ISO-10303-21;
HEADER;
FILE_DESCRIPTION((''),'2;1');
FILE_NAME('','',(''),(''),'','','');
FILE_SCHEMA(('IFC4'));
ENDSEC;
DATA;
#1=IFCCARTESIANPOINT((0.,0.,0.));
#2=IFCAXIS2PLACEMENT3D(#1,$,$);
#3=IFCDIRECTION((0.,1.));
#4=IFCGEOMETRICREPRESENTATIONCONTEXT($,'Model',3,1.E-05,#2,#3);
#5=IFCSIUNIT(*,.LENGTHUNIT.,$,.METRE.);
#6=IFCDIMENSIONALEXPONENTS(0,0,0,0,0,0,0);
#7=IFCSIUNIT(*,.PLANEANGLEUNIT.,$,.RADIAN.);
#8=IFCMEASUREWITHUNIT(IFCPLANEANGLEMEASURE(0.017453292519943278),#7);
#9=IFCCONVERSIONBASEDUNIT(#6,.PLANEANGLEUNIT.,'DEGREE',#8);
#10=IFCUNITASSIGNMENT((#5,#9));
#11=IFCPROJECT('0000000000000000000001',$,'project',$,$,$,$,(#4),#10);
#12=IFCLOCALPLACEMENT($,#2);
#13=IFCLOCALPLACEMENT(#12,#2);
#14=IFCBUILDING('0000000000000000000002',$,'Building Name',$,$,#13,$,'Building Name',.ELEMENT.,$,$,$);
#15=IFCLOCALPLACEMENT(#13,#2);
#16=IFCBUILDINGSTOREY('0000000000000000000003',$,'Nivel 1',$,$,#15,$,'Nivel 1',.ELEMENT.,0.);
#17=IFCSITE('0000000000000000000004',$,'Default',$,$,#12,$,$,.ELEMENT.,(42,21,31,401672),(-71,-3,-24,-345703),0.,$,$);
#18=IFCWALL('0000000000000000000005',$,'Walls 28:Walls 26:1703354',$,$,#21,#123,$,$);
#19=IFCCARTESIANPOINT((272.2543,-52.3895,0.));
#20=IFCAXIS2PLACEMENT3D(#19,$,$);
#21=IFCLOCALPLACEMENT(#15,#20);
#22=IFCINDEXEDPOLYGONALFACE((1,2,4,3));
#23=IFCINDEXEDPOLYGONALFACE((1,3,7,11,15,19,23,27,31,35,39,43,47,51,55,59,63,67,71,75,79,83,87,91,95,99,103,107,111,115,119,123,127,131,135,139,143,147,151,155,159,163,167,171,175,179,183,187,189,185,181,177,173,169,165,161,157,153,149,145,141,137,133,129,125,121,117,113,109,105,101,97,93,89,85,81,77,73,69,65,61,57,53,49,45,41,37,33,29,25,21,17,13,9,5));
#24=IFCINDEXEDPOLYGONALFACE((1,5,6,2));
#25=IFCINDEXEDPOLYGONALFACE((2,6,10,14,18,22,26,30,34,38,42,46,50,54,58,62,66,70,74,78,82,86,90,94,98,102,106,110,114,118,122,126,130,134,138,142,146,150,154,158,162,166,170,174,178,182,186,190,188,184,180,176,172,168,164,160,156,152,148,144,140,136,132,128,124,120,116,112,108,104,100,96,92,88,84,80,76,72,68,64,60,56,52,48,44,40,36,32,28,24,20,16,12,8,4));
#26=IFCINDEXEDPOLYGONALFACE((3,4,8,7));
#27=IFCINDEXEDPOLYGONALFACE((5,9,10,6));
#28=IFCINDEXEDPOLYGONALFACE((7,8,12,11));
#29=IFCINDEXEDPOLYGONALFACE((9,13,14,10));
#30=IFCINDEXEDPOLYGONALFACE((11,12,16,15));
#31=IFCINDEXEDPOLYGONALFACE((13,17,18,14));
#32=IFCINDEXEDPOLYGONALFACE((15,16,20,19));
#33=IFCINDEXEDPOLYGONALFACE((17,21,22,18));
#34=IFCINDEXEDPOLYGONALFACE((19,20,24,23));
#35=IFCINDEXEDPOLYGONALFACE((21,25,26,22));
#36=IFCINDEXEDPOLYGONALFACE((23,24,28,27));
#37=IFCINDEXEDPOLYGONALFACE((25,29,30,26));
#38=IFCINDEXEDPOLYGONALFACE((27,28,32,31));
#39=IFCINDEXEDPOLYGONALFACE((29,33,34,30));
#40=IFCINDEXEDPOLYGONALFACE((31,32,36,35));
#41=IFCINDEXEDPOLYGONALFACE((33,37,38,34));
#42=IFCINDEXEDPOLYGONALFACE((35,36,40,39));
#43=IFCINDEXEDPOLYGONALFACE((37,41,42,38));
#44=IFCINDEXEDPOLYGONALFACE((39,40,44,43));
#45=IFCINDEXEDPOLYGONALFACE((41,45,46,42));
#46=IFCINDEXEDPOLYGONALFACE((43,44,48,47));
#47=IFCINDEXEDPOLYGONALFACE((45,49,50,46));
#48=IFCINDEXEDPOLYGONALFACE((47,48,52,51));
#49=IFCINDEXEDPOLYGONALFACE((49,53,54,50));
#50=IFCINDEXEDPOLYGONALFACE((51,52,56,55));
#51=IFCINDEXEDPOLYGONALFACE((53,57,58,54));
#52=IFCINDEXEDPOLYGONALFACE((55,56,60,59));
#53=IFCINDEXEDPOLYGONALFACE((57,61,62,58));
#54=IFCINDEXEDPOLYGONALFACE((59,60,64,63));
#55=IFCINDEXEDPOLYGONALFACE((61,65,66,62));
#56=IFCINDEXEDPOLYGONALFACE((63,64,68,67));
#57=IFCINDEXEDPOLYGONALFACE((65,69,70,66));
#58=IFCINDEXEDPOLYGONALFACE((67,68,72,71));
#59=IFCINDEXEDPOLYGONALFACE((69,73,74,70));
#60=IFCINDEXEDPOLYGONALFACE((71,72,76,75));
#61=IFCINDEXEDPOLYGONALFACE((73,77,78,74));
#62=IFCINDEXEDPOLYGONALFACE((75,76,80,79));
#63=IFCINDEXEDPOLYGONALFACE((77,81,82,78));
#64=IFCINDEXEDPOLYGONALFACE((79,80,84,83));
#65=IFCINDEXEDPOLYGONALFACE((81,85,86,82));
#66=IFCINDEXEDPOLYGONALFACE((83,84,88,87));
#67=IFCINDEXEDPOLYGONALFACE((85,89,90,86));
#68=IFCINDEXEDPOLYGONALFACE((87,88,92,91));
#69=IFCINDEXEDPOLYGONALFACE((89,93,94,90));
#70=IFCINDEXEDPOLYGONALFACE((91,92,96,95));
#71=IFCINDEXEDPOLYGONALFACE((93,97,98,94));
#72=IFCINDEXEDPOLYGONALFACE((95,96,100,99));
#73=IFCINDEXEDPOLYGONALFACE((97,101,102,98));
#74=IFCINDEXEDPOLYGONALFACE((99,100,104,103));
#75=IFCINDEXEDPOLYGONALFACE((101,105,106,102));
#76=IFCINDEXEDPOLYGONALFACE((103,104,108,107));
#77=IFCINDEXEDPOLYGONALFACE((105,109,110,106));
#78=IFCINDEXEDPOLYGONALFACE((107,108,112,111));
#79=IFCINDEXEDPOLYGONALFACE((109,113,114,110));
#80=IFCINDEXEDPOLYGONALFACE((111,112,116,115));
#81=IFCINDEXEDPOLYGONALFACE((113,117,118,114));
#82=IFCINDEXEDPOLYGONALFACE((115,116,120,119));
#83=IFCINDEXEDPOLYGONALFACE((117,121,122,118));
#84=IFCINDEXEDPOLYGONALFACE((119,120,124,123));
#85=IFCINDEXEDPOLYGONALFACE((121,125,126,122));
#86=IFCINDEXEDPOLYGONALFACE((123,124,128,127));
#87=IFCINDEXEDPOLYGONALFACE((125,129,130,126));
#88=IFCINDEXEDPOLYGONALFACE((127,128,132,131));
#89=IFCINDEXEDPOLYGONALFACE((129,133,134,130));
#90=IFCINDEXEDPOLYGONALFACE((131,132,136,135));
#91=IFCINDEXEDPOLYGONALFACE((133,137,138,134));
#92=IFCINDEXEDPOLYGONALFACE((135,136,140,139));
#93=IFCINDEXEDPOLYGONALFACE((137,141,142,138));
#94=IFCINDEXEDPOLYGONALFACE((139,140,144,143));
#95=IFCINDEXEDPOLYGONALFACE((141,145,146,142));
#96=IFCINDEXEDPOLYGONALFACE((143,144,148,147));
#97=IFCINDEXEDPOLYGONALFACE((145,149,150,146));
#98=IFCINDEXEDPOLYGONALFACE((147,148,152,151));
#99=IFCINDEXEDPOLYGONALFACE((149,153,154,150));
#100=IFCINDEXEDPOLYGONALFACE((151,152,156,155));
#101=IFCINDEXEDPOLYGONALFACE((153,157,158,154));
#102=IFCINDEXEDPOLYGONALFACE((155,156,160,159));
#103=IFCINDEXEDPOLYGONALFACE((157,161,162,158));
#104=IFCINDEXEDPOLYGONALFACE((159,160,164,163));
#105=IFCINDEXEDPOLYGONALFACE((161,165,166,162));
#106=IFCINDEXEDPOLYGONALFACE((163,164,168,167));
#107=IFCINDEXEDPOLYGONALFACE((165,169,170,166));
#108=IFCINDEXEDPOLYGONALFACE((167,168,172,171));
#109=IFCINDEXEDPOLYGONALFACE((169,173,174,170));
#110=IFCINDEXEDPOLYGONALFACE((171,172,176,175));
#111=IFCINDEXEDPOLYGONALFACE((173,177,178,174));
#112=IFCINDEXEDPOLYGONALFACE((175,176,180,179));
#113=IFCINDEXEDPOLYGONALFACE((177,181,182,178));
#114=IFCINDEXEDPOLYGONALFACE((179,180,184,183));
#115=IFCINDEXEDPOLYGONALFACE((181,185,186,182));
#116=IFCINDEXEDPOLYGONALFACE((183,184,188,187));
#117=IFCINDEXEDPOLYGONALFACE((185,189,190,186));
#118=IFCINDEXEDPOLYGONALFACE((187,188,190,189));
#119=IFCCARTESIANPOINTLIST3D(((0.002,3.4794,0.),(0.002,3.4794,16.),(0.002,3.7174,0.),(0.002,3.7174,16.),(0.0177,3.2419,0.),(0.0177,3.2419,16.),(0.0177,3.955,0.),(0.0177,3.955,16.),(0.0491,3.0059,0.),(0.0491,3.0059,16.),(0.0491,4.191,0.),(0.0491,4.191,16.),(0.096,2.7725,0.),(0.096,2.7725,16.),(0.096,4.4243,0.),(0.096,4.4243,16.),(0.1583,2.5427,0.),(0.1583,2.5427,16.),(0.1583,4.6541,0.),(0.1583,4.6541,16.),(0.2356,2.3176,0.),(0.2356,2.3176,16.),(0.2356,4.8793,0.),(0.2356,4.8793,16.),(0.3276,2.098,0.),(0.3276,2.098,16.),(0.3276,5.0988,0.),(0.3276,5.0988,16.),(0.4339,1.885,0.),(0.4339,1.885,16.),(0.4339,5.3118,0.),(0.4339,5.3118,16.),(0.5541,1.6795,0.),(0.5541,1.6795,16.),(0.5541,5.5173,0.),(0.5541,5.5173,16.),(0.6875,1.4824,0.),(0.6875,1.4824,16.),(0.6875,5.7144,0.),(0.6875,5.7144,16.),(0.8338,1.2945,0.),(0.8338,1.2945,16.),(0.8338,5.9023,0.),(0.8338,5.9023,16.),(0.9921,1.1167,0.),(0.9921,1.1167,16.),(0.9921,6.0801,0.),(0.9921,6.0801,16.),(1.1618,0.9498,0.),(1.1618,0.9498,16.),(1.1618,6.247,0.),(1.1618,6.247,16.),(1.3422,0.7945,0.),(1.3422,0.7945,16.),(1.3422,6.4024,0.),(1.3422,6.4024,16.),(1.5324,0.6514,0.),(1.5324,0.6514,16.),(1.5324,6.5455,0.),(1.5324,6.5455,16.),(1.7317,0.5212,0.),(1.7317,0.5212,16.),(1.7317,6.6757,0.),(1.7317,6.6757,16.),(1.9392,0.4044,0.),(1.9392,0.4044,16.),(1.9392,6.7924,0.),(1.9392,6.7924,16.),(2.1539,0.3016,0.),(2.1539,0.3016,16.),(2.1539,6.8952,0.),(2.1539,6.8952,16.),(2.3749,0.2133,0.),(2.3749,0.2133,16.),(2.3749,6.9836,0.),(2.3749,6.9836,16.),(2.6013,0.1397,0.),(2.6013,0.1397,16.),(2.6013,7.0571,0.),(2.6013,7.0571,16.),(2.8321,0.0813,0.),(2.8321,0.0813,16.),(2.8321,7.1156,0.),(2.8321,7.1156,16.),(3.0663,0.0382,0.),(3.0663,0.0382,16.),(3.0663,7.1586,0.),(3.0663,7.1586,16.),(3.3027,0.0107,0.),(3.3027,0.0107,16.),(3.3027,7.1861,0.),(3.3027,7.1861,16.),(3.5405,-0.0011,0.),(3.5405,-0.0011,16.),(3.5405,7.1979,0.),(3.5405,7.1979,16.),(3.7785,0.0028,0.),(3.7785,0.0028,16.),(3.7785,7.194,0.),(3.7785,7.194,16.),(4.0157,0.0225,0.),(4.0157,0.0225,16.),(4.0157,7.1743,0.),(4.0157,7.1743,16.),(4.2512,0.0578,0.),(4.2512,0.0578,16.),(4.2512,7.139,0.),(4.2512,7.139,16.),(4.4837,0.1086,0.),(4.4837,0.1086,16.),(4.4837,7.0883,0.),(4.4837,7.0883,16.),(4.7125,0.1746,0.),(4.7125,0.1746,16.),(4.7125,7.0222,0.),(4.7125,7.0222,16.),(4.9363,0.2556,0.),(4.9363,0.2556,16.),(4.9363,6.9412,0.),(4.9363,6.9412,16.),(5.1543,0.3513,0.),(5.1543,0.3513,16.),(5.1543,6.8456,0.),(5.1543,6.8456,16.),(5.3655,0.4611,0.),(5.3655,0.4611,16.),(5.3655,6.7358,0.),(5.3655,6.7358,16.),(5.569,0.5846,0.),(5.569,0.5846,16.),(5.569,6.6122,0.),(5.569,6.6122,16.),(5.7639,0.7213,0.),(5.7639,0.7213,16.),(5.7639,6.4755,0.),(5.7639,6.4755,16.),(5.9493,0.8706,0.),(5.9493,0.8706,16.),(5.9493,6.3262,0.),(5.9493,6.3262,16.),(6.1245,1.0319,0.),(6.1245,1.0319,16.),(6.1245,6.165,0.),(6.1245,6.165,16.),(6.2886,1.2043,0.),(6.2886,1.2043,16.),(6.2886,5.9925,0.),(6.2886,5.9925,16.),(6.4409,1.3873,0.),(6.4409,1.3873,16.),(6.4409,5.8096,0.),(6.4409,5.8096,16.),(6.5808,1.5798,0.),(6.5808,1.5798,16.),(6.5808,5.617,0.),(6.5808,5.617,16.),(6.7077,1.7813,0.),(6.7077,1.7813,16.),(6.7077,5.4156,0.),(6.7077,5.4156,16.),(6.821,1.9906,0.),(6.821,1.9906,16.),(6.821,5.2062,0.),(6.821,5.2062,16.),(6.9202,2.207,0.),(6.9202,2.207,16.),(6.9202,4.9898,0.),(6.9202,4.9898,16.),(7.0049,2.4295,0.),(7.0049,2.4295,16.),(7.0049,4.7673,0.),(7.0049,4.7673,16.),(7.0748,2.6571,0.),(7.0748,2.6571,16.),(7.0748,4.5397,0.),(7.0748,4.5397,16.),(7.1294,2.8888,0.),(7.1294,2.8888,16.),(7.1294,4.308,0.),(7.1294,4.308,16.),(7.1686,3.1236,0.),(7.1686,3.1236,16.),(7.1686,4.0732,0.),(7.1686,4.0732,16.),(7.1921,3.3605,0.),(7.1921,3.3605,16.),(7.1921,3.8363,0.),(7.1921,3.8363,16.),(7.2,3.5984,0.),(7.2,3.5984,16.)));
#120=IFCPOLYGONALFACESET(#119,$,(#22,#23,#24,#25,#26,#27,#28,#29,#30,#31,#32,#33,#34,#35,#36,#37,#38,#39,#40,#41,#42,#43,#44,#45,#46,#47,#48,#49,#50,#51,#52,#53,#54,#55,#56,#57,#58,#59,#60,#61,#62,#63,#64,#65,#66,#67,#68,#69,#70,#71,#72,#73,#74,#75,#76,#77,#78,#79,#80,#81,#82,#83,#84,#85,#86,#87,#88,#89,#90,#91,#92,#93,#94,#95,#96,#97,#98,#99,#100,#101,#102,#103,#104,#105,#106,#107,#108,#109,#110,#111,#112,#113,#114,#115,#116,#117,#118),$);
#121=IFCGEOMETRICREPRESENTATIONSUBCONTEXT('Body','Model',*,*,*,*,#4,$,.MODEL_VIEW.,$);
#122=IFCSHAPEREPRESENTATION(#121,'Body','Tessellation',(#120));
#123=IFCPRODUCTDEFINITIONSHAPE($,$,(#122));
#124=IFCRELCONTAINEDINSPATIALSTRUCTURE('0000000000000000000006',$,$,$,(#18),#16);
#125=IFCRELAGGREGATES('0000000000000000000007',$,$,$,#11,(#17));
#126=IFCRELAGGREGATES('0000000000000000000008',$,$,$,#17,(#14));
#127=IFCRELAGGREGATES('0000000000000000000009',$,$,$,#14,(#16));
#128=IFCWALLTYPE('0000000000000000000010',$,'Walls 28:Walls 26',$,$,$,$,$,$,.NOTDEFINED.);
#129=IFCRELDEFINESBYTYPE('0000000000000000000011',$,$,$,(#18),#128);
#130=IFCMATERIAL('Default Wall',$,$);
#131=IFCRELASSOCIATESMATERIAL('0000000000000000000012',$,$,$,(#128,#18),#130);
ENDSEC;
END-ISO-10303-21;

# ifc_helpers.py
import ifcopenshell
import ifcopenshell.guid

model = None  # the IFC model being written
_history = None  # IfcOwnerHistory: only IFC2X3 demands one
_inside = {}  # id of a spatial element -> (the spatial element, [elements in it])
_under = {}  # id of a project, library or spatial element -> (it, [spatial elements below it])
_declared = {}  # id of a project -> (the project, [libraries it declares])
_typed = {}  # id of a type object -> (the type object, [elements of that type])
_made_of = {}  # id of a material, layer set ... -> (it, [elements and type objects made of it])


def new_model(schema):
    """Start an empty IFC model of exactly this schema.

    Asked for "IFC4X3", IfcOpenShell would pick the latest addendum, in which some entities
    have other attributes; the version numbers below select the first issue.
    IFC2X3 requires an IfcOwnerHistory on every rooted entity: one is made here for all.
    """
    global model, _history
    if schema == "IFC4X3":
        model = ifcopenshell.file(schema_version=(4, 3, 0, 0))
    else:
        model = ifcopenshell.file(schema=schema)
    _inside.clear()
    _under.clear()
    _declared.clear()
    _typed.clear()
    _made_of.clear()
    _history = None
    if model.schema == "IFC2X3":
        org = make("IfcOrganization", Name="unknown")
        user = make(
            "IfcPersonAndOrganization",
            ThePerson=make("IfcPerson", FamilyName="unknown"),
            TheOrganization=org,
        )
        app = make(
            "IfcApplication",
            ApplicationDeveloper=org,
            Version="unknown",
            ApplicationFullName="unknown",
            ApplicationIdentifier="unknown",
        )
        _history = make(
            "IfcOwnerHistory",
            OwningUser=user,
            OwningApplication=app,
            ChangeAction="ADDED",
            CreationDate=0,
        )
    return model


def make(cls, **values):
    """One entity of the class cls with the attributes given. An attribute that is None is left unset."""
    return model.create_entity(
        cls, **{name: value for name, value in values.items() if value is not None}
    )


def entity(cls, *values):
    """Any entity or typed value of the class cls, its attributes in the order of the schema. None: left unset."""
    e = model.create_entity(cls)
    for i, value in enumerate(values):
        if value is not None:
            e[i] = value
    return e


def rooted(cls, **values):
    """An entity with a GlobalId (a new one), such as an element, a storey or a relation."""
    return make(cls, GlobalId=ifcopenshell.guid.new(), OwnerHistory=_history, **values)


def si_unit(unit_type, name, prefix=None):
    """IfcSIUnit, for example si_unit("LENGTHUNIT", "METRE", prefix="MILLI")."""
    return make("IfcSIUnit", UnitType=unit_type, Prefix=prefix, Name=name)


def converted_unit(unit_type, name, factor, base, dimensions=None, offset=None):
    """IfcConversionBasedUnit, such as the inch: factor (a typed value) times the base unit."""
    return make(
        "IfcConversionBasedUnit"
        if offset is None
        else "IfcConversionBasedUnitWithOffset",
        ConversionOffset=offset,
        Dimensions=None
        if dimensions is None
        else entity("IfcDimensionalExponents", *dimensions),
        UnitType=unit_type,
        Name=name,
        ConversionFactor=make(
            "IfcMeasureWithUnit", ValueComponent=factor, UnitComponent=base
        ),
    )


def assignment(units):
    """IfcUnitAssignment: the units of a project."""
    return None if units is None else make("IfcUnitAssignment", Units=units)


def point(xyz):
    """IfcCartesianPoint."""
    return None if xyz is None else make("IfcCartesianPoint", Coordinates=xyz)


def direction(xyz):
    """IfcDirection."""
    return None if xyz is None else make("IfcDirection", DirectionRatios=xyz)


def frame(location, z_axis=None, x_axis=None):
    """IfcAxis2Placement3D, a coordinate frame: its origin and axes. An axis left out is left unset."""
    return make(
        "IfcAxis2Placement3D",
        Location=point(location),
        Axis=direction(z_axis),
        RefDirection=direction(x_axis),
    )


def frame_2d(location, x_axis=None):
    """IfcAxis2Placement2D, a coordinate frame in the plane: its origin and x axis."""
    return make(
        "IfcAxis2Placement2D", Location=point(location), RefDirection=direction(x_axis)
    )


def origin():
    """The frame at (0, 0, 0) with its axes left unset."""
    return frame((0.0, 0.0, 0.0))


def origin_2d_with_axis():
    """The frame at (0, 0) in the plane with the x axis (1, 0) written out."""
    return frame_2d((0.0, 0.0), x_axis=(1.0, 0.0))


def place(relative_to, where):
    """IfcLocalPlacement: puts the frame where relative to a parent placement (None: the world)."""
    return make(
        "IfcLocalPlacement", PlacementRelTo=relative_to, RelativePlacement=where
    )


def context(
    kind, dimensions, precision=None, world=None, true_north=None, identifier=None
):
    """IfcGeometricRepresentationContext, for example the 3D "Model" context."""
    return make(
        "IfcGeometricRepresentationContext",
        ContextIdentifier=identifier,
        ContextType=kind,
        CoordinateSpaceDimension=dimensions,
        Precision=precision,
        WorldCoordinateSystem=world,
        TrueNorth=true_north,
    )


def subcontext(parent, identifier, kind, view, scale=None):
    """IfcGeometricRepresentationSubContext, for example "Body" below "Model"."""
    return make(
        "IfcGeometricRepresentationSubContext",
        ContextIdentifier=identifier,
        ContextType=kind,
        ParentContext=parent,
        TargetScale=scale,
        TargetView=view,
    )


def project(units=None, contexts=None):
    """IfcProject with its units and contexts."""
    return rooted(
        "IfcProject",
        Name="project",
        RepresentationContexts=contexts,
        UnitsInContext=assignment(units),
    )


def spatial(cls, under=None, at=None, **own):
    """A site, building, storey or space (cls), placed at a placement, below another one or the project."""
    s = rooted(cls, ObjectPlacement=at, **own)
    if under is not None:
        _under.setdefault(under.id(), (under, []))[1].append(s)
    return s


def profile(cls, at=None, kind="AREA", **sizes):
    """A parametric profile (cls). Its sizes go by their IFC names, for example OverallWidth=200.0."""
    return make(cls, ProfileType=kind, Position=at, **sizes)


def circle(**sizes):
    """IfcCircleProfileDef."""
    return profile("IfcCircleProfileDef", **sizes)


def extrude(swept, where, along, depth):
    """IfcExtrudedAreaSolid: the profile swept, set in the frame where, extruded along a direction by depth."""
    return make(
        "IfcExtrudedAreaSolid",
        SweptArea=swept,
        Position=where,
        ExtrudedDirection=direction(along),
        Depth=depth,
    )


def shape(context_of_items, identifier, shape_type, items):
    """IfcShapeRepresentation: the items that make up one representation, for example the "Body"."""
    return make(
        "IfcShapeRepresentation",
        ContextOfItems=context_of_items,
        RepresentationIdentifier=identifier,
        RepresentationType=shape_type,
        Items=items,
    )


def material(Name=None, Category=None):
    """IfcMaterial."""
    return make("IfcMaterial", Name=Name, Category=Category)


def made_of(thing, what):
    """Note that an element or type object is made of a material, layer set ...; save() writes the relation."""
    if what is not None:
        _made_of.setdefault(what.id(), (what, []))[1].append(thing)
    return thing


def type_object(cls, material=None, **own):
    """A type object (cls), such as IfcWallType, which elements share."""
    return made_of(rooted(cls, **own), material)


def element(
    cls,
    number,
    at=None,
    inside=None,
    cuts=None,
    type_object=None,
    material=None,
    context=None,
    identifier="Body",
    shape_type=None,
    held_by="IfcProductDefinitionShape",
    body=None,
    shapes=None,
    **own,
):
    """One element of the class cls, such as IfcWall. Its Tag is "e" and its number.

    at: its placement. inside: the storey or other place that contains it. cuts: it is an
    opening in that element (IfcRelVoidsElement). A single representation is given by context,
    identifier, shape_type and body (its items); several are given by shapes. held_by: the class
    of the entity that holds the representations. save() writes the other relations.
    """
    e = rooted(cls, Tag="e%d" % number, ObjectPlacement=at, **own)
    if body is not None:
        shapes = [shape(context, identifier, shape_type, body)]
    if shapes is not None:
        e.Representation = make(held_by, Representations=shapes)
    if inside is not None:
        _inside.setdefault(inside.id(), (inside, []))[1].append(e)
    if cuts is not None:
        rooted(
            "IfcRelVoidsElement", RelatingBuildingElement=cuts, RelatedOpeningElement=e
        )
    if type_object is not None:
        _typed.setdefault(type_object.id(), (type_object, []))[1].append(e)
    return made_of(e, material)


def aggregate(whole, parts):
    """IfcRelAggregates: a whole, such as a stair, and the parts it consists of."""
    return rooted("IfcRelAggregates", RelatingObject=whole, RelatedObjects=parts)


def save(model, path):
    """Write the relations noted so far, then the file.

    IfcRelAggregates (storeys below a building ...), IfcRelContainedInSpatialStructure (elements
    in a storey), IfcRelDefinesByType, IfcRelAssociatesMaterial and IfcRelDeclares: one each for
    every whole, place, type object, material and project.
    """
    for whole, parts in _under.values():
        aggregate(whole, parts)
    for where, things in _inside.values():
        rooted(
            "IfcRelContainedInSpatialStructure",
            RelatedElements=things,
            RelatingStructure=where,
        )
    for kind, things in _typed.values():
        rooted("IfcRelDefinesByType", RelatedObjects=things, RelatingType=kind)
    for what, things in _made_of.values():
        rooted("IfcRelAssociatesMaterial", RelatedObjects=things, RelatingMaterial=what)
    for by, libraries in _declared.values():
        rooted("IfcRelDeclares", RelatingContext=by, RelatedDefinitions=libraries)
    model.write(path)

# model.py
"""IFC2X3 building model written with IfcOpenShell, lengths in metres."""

from ifc_helpers import new_model, entity, si_unit, converted_unit, direction, frame, origin, origin_2d_with_axis, place, context, subcontext, project, spatial, circle, extrude, material, type_object, element, save


model = new_model("IFC2X3")

# Units and contexts
model_context = context("Model", 3, precision=1e-05, world=origin(), true_north=direction((0.0, 1.0)))
body_context = subcontext(model_context, "Body", "Model", "MODEL_VIEW")
ifc_project = project(units=[si_unit("LENGTHUNIT", "METRE"), converted_unit("PLANEANGLEUNIT", "DEGREE", entity("IfcPlaneAngleMeasure", 0.017453292519943278), si_unit("PLANEANGLEUNIT", "RADIAN"), dimensions=[0, 0, 0, 0, 0, 0, 0])], contexts=[model_context])

# Site, building, storey
site_placement = place(None, origin())
site = spatial("IfcSite", under=ifc_project, at=site_placement, Name="Default", CompositionType="ELEMENT", RefLatitude=(42, 21, 31, 401672), RefLongitude=(-71, -3, -24, -345703), RefElevation=0.0)
building_placement = place(site_placement, origin())
building = spatial("IfcBuilding", under=site, at=building_placement, Name="Building Name", LongName="Building Name", CompositionType="ELEMENT")
storey_placement = place(building_placement, origin())
storey = spatial("IfcBuildingStorey", under=building, at=storey_placement, Name="Nivel 1", LongName="Nivel 1", CompositionType="ELEMENT", Elevation=0.0)

# Wall
ifc_material_1 = material(Name="Default Wall")
wall_type_1 = type_object("IfcWallType", Name="Walls 28:Walls 26", PredefinedType="NOTDEFINED", material=ifc_material_1)
wall_1_placement = place(storey_placement, frame((272.2543, -52.3895, 0.0)))
element("IfcWall", 1, at=wall_1_placement, inside=storey, type_object=wall_type_1, material=ifc_material_1, Name="Walls 28:Walls 26:1703354", context=body_context, shape_type="SweptSolid", body=[
    extrude(circle(Radius=3.6, at=origin_2d_with_axis()), frame((3.6, 3.5984, 0.0)), (0.0, 0.0, 1.0), 16.0),
])

save(model, "model.ifc")
